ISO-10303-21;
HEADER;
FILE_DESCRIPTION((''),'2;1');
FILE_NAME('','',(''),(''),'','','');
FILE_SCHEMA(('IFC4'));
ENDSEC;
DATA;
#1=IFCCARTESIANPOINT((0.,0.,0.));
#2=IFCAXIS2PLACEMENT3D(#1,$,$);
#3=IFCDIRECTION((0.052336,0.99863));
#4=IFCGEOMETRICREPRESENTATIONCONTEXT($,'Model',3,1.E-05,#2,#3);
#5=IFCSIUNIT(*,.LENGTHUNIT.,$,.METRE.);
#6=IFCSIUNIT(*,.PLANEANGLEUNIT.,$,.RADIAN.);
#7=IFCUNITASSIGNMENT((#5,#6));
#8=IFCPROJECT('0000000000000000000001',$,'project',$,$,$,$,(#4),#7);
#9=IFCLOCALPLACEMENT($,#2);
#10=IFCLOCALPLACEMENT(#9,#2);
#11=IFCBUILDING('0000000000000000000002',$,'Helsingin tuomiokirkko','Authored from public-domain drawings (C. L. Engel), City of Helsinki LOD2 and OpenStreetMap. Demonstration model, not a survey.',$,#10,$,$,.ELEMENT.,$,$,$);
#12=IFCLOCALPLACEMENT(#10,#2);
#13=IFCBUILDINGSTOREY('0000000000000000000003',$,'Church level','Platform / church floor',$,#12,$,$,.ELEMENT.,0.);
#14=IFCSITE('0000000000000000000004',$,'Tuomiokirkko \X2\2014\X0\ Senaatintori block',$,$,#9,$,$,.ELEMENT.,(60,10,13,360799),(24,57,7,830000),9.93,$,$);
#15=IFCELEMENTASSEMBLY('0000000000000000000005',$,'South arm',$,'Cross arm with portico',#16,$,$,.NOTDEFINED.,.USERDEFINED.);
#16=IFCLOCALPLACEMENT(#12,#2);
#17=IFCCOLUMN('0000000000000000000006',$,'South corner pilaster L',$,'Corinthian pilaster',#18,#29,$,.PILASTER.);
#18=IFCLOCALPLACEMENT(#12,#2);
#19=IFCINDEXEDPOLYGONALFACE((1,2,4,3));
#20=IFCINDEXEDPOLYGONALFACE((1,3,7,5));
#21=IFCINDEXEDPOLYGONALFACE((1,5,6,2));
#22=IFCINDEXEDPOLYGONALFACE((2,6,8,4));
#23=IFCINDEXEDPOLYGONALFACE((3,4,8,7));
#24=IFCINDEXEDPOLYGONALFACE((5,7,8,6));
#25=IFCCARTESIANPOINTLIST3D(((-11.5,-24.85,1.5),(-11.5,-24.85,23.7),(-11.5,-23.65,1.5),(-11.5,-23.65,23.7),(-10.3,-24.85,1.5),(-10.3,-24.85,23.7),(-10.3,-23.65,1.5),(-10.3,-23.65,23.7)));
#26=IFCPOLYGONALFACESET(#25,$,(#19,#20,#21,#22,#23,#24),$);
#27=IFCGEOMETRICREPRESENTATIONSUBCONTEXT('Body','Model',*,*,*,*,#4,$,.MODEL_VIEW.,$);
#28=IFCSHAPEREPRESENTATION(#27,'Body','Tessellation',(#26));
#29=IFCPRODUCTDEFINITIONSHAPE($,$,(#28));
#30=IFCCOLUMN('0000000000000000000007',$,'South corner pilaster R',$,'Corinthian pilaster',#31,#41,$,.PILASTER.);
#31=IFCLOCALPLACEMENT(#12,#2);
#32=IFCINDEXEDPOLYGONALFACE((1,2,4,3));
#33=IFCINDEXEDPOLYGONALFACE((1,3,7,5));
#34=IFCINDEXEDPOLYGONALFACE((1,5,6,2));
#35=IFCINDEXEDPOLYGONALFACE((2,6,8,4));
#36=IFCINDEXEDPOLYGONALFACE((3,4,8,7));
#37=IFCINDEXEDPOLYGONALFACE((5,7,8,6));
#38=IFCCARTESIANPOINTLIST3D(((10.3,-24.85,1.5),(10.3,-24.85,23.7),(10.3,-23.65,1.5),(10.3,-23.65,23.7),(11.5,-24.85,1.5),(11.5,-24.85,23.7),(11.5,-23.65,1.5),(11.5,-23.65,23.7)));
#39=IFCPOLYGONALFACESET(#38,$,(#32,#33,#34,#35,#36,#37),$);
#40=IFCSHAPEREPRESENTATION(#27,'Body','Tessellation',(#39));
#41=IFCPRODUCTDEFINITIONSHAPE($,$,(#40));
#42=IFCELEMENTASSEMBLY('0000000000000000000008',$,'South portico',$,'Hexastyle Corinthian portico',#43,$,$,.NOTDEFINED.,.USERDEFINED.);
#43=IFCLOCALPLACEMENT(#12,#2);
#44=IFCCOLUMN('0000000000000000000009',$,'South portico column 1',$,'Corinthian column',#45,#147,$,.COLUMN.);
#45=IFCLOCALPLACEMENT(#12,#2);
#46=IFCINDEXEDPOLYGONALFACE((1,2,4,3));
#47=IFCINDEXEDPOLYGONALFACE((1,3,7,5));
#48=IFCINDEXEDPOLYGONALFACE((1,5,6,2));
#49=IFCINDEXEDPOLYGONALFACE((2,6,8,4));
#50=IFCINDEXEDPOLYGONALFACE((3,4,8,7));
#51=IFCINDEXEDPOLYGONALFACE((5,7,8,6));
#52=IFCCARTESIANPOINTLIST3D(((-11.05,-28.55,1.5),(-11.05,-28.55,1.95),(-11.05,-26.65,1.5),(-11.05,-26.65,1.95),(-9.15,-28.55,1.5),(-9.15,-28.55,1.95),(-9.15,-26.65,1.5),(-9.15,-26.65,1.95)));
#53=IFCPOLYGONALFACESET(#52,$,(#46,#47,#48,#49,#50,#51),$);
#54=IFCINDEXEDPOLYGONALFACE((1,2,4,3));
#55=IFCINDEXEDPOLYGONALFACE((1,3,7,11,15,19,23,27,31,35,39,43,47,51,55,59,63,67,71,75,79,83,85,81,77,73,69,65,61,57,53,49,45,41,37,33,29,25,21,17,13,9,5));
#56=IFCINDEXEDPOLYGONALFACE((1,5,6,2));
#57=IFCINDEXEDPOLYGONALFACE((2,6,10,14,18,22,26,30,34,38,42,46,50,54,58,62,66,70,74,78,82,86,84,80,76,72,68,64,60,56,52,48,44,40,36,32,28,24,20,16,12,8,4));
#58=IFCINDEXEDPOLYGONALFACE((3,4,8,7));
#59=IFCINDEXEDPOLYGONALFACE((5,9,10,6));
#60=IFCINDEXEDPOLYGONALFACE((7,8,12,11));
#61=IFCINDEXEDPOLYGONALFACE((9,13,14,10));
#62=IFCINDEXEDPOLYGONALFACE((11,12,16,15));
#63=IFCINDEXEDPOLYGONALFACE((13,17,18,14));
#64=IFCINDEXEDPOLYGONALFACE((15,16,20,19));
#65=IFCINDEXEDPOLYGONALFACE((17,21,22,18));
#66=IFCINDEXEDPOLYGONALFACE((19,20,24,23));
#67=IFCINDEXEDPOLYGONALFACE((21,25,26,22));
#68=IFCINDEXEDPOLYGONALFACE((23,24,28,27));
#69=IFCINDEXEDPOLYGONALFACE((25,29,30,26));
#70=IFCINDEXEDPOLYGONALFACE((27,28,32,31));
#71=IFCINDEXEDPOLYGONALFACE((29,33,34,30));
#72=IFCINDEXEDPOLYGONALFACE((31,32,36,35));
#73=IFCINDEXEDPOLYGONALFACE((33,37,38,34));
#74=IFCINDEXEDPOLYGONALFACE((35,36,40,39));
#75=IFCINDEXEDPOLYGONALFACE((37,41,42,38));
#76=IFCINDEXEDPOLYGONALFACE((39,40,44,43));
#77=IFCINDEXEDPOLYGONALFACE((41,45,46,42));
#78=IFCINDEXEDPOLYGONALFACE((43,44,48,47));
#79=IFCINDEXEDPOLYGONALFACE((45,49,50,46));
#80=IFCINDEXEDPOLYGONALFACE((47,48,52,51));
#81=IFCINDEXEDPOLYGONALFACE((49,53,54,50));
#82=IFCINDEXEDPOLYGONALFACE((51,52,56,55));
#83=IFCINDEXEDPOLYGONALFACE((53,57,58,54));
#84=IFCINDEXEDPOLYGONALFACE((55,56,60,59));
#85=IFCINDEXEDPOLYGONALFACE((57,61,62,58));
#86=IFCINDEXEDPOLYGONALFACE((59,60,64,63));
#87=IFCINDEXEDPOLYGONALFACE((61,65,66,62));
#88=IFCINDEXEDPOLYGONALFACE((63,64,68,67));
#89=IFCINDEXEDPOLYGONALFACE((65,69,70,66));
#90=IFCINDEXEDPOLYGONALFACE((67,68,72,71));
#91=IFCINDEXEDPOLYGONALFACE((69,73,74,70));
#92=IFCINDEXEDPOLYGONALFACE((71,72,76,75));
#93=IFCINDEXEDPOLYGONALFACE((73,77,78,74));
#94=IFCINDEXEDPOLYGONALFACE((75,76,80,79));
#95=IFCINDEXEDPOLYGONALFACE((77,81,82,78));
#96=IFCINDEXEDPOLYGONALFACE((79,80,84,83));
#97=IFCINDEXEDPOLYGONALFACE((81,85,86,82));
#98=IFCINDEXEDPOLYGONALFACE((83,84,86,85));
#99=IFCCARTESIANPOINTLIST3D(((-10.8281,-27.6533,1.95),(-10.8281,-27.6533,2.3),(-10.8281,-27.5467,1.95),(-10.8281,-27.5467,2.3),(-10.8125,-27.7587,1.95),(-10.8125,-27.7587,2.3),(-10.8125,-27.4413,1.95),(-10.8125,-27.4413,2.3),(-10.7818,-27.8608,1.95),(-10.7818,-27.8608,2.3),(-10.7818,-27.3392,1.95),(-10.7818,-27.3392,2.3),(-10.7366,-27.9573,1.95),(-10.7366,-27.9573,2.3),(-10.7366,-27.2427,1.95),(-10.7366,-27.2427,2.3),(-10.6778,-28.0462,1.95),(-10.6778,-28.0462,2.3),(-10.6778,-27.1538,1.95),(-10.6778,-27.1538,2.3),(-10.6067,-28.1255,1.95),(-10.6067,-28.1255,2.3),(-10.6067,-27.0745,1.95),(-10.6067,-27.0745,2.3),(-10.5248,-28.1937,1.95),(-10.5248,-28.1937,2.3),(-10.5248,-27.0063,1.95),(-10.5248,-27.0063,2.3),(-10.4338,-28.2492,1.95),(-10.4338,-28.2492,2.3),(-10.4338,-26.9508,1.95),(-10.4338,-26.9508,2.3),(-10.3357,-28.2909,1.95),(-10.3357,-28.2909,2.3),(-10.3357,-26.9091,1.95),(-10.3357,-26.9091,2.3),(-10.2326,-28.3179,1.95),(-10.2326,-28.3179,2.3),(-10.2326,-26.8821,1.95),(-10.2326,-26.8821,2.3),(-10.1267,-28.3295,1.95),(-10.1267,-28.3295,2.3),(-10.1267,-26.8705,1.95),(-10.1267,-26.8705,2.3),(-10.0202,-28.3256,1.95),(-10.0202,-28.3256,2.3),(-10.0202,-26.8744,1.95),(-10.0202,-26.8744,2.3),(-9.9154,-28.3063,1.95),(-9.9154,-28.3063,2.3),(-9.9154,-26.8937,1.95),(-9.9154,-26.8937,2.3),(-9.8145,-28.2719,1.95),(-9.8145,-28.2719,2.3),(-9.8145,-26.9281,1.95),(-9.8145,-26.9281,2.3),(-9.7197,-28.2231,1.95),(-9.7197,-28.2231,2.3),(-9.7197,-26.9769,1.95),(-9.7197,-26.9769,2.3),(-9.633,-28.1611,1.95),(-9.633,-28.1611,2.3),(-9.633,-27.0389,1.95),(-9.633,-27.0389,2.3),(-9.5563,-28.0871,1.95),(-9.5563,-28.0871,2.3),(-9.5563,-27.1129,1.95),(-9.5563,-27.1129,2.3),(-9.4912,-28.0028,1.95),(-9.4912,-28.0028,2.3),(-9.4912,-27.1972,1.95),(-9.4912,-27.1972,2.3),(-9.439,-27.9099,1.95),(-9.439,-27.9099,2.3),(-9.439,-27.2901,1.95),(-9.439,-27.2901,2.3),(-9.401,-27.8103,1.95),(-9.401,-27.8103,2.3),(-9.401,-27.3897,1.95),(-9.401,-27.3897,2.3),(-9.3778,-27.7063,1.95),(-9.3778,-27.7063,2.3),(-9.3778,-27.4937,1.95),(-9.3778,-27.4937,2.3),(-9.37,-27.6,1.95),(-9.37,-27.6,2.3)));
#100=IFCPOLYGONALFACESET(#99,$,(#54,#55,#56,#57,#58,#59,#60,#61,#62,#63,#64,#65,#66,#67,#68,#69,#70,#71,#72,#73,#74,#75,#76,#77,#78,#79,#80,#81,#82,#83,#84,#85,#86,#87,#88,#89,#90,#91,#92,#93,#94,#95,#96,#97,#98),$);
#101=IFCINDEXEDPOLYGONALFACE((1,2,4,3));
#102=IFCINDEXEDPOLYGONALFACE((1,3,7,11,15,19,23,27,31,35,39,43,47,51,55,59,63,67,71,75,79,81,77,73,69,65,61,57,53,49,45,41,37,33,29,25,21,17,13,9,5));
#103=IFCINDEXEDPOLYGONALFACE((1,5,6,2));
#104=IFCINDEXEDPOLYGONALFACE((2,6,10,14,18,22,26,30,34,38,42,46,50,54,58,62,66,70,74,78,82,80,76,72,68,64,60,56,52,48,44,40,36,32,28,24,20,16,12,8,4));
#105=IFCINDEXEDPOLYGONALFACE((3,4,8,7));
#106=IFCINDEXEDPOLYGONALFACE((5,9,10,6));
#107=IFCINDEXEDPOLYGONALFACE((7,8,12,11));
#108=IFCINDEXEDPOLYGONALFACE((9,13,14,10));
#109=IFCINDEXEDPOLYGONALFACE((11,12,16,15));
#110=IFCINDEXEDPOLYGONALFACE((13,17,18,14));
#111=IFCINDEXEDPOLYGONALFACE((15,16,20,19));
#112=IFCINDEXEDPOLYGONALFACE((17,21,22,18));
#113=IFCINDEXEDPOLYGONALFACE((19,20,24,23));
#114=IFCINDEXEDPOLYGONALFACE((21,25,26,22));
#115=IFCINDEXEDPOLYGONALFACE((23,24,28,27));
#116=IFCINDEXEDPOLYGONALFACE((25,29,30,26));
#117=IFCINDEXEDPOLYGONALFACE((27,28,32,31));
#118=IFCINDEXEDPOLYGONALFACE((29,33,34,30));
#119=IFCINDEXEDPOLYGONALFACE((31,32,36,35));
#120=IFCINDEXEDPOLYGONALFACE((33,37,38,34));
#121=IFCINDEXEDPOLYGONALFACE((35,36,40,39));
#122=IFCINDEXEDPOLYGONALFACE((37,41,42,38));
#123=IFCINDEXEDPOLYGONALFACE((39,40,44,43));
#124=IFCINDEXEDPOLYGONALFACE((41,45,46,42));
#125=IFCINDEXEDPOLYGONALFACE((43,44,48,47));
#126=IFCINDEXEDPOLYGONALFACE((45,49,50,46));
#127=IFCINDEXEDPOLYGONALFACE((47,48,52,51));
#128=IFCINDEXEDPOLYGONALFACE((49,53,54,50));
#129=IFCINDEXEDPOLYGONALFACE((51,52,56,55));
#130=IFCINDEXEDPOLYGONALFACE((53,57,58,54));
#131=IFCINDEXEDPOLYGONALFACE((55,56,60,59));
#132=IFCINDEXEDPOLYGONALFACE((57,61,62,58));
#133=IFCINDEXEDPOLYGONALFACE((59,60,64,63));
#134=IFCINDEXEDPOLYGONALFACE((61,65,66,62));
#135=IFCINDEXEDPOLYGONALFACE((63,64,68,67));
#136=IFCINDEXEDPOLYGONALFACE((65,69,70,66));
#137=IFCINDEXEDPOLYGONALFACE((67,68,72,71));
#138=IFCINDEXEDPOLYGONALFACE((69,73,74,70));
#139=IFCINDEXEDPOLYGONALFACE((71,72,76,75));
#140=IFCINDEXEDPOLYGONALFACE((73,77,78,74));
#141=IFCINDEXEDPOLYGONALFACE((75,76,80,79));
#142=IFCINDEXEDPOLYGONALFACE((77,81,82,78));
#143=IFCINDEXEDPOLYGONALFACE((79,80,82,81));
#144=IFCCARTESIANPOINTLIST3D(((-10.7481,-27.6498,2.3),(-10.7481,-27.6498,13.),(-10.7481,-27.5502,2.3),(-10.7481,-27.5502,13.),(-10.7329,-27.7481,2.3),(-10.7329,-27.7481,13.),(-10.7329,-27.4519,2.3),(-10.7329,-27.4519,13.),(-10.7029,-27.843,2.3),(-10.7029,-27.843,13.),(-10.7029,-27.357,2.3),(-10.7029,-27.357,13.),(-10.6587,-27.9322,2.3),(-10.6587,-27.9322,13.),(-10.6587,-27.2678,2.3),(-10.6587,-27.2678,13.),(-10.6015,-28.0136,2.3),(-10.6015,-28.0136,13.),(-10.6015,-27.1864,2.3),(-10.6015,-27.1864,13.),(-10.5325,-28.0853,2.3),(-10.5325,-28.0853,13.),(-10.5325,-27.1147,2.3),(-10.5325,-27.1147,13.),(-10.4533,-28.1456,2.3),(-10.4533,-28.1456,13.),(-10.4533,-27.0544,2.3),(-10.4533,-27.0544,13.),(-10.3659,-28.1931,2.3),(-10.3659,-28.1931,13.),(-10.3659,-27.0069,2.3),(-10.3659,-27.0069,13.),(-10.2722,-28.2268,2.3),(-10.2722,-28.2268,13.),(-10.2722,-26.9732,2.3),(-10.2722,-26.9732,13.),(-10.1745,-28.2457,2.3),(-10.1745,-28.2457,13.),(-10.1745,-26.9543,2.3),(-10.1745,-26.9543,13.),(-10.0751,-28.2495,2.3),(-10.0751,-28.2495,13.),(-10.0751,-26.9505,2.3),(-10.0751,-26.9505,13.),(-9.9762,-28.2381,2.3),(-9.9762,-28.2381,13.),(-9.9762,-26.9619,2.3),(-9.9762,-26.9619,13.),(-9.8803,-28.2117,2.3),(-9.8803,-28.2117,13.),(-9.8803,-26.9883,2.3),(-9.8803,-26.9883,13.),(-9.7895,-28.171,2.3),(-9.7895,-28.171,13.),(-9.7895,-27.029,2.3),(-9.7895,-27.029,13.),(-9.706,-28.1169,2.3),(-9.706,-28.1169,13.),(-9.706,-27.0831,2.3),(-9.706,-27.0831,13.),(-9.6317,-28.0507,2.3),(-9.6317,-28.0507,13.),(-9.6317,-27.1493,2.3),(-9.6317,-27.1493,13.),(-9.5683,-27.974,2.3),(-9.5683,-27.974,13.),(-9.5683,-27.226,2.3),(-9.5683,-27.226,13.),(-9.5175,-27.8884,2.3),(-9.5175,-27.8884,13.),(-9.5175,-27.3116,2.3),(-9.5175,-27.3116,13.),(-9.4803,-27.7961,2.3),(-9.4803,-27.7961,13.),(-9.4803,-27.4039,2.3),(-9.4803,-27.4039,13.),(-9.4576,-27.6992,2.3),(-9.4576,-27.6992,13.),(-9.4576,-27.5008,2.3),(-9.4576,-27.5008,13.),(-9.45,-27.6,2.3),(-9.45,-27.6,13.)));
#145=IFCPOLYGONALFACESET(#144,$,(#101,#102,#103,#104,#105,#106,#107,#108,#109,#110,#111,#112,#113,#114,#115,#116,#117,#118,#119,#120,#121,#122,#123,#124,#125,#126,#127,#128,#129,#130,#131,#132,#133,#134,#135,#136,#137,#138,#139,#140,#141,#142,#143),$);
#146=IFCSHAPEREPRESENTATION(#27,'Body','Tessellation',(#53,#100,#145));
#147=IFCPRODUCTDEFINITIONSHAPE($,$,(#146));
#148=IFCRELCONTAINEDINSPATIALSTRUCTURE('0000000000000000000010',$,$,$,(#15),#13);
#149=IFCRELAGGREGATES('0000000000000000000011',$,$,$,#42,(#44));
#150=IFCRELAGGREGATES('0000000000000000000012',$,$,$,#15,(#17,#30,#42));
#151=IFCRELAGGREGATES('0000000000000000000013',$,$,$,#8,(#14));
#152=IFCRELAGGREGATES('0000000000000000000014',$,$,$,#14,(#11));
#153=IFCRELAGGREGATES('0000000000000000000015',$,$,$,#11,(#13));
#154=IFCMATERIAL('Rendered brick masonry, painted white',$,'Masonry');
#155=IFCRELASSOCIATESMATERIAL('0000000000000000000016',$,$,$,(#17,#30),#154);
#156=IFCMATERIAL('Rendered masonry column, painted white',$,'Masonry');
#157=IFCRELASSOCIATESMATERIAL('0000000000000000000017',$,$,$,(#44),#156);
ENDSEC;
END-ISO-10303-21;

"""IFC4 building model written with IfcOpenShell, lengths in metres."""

from ifc_helpers import new_model, si_unit, direction, frame, origin, origin_2d_with_axis, place, context, subcontext, project, spatial, rectangle, circle, extrude, material, element, aggregate, save


model = new_model("IFC4")

# Units and contexts
model_context = context("Model", 3, precision=1e-05, world=origin(), true_north=direction((0.052336, 0.99863)))
body_context = subcontext(model_context, "Body", "Model", "MODEL_VIEW")
ifc_project = project(units=[si_unit("LENGTHUNIT", "METRE"), si_unit("PLANEANGLEUNIT", "RADIAN")], contexts=[model_context])

# Site, building, storey
site_placement = place(None, origin())
site = spatial("IfcSite", under=ifc_project, at=site_placement, Name="Tuomiokirkko — Senaatintori block", CompositionType="ELEMENT", RefLatitude=(60, 10, 13, 360799), RefLongitude=(24, 57, 7, 830000), RefElevation=9.93)
building_placement = place(site_placement, origin())
building = spatial("IfcBuilding", under=site, at=building_placement, Name="Helsingin tuomiokirkko", Description="Authored from public-domain drawings (C. L. Engel), City of Helsinki LOD2 and OpenStreetMap. Demonstration model, not a survey.", CompositionType="ELEMENT")
storey_placement = place(building_placement, origin())
storey = spatial("IfcBuildingStorey", under=building, at=storey_placement, Name="Church level", Description="Platform / church floor", CompositionType="ELEMENT", Elevation=0.0)

# Element assemblies, columns
assembly_1_placement = place(building_placement, origin())
assembly_1 = element("IfcElementAssembly", 1, at=assembly_1_placement, inside=storey, Name="South arm", ObjectType="Cross arm with portico", AssemblyPlace="NOTDEFINED", PredefinedType="USERDEFINED")
ifc_material_1 = material(Name="Rendered brick masonry, painted white", Category="Masonry")
column_1_placement = place(building_placement, origin())
column_1 = element("IfcColumn", 2, at=column_1_placement, material=ifc_material_1, Name="South corner pilaster L", ObjectType="Corinthian pilaster", PredefinedType="PILASTER", context=body_context, shape_type="SweptSolid", body=[
    extrude(rectangle(XDim=1.2, YDim=1.2, at=origin_2d_with_axis()), frame((-10.9, -24.25, 1.5)), (0.0, 0.0, 1.0), 22.2),
])
column_2_placement = place(building_placement, origin())
column_2 = element("IfcColumn", 3, at=column_2_placement, material=ifc_material_1, Name="South corner pilaster R", ObjectType="Corinthian pilaster", PredefinedType="PILASTER", context=body_context, shape_type="SweptSolid", body=[
    extrude(rectangle(XDim=1.2, YDim=1.2, at=origin_2d_with_axis()), frame((10.9, -24.25, 1.5)), (0.0, 0.0, 1.0), 22.2),
])
assembly_2_placement = place(building_placement, origin())
assembly_2 = element("IfcElementAssembly", 4, at=assembly_2_placement, Name="South portico", ObjectType="Hexastyle Corinthian portico", AssemblyPlace="NOTDEFINED", PredefinedType="USERDEFINED")
ifc_material_2 = material(Name="Rendered masonry column, painted white", Category="Masonry")
column_3_placement = place(building_placement, origin())
column_3 = element("IfcColumn", 5, at=column_3_placement, material=ifc_material_2, Name="South portico column 1", ObjectType="Corinthian column", PredefinedType="COLUMN", context=body_context, shape_type="SweptSolid", body=[
    extrude(rectangle(XDim=1.9, YDim=1.9, at=origin_2d_with_axis()), frame((-10.1, -27.6, 1.5)), (0.0, 0.0, 1.0), 0.45),
    extrude(circle(Radius=0.73, at=origin_2d_with_axis()), frame((-10.1, -27.6, 1.95)), (0.0, 0.0, 1.0), 0.35),
    extrude(circle(Radius=0.65, at=origin_2d_with_axis()), frame((-10.1, -27.6, 2.3)), (0.0, 0.0, 1.0), 10.7),
])
aggregate(assembly_2, [column_3])
aggregate(assembly_1, [column_1, column_2, assembly_2])

save(model, "model.ifc")
